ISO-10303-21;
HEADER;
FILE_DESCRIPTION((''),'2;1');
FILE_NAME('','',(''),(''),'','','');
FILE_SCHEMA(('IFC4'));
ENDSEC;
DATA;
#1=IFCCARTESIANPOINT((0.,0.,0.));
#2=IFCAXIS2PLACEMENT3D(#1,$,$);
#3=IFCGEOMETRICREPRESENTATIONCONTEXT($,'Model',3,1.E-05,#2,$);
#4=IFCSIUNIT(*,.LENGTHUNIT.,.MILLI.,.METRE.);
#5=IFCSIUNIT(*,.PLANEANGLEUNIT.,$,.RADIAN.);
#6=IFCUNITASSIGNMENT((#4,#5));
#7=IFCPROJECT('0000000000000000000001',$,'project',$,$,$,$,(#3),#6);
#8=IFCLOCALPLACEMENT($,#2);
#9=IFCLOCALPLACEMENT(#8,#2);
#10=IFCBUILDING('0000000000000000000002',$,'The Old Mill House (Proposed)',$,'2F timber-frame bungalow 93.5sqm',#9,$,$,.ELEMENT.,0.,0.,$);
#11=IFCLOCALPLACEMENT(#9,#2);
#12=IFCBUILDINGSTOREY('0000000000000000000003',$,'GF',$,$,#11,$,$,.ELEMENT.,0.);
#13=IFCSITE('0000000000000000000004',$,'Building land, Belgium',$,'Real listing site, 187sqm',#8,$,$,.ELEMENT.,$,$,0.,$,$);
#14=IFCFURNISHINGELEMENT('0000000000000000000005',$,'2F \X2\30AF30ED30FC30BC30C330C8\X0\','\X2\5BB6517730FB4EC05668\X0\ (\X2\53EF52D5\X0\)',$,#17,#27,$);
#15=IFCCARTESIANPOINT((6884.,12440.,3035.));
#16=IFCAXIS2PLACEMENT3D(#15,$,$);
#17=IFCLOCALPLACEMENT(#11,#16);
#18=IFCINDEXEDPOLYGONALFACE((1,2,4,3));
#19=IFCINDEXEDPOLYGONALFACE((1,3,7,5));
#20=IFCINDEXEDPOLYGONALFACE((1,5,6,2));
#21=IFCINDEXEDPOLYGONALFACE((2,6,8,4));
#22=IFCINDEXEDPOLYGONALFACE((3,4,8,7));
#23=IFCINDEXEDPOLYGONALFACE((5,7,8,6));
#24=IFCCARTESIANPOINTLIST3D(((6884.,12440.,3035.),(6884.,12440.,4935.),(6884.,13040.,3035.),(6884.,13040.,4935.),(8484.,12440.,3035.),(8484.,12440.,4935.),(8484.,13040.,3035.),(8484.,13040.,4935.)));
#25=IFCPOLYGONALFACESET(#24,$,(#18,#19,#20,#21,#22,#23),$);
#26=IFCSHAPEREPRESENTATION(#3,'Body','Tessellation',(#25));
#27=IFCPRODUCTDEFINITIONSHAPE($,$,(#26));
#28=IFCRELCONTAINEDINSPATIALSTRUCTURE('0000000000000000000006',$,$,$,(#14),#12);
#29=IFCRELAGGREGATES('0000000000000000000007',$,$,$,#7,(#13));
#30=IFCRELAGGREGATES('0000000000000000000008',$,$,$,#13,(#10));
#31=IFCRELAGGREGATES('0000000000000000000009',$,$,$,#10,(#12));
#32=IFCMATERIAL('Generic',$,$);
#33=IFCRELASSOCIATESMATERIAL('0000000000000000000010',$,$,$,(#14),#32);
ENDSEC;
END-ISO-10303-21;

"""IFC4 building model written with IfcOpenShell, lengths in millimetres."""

from ifc_helpers import new_model, si_unit, frame, frame_2d, origin, place, context, project, spatial, rectangle, extrude, material, element, save


model = new_model("IFC4")

# Units and contexts
model_context = context("Model", 3, precision=1e-05, world=origin())
ifc_project = project(units=[si_unit("LENGTHUNIT", "METRE", prefix="MILLI"), si_unit("PLANEANGLEUNIT", "RADIAN")], contexts=[model_context])

# Site, building, storey
site_placement = place(None, origin())
site = spatial("IfcSite", under=ifc_project, at=site_placement, Name="Building land, Belgium", ObjectType="Real listing site, 187sqm", CompositionType="ELEMENT", RefElevation=0.0)
building_placement = place(site_placement, origin())
building = spatial("IfcBuilding", under=site, at=building_placement, Name="The Old Mill House (Proposed)", ObjectType="2F timber-frame bungalow 93.5sqm", CompositionType="ELEMENT", ElevationOfRefHeight=0.0, ElevationOfTerrain=0.0)
storey_placement = place(building_placement, origin())
storey = spatial("IfcBuildingStorey", under=building, at=storey_placement, Name="GF", CompositionType="ELEMENT", Elevation=0.0)

# Shared definitions
ifc_material_1 = material(Name="Generic")

# Furnishing element
furnishing_1_placement = place(storey_placement, frame((6884.0, 12440.0, 3035.0)))
element("IfcFurnishingElement", 1, at=furnishing_1_placement, inside=storey, material=ifc_material_1, Name="2F クローゼット", Description="家具・什器 (可動)", context=model_context, shape_type="SweptSolid", body=[
    extrude(rectangle(XDim=1600.0, YDim=600.0, at=frame_2d((800.0, 300.0))), frame((6884.0, 12440.0, 3035.0)), (0.0, 0.0, 1.0), 1900.0),
])

save(model, "model.ifc")
